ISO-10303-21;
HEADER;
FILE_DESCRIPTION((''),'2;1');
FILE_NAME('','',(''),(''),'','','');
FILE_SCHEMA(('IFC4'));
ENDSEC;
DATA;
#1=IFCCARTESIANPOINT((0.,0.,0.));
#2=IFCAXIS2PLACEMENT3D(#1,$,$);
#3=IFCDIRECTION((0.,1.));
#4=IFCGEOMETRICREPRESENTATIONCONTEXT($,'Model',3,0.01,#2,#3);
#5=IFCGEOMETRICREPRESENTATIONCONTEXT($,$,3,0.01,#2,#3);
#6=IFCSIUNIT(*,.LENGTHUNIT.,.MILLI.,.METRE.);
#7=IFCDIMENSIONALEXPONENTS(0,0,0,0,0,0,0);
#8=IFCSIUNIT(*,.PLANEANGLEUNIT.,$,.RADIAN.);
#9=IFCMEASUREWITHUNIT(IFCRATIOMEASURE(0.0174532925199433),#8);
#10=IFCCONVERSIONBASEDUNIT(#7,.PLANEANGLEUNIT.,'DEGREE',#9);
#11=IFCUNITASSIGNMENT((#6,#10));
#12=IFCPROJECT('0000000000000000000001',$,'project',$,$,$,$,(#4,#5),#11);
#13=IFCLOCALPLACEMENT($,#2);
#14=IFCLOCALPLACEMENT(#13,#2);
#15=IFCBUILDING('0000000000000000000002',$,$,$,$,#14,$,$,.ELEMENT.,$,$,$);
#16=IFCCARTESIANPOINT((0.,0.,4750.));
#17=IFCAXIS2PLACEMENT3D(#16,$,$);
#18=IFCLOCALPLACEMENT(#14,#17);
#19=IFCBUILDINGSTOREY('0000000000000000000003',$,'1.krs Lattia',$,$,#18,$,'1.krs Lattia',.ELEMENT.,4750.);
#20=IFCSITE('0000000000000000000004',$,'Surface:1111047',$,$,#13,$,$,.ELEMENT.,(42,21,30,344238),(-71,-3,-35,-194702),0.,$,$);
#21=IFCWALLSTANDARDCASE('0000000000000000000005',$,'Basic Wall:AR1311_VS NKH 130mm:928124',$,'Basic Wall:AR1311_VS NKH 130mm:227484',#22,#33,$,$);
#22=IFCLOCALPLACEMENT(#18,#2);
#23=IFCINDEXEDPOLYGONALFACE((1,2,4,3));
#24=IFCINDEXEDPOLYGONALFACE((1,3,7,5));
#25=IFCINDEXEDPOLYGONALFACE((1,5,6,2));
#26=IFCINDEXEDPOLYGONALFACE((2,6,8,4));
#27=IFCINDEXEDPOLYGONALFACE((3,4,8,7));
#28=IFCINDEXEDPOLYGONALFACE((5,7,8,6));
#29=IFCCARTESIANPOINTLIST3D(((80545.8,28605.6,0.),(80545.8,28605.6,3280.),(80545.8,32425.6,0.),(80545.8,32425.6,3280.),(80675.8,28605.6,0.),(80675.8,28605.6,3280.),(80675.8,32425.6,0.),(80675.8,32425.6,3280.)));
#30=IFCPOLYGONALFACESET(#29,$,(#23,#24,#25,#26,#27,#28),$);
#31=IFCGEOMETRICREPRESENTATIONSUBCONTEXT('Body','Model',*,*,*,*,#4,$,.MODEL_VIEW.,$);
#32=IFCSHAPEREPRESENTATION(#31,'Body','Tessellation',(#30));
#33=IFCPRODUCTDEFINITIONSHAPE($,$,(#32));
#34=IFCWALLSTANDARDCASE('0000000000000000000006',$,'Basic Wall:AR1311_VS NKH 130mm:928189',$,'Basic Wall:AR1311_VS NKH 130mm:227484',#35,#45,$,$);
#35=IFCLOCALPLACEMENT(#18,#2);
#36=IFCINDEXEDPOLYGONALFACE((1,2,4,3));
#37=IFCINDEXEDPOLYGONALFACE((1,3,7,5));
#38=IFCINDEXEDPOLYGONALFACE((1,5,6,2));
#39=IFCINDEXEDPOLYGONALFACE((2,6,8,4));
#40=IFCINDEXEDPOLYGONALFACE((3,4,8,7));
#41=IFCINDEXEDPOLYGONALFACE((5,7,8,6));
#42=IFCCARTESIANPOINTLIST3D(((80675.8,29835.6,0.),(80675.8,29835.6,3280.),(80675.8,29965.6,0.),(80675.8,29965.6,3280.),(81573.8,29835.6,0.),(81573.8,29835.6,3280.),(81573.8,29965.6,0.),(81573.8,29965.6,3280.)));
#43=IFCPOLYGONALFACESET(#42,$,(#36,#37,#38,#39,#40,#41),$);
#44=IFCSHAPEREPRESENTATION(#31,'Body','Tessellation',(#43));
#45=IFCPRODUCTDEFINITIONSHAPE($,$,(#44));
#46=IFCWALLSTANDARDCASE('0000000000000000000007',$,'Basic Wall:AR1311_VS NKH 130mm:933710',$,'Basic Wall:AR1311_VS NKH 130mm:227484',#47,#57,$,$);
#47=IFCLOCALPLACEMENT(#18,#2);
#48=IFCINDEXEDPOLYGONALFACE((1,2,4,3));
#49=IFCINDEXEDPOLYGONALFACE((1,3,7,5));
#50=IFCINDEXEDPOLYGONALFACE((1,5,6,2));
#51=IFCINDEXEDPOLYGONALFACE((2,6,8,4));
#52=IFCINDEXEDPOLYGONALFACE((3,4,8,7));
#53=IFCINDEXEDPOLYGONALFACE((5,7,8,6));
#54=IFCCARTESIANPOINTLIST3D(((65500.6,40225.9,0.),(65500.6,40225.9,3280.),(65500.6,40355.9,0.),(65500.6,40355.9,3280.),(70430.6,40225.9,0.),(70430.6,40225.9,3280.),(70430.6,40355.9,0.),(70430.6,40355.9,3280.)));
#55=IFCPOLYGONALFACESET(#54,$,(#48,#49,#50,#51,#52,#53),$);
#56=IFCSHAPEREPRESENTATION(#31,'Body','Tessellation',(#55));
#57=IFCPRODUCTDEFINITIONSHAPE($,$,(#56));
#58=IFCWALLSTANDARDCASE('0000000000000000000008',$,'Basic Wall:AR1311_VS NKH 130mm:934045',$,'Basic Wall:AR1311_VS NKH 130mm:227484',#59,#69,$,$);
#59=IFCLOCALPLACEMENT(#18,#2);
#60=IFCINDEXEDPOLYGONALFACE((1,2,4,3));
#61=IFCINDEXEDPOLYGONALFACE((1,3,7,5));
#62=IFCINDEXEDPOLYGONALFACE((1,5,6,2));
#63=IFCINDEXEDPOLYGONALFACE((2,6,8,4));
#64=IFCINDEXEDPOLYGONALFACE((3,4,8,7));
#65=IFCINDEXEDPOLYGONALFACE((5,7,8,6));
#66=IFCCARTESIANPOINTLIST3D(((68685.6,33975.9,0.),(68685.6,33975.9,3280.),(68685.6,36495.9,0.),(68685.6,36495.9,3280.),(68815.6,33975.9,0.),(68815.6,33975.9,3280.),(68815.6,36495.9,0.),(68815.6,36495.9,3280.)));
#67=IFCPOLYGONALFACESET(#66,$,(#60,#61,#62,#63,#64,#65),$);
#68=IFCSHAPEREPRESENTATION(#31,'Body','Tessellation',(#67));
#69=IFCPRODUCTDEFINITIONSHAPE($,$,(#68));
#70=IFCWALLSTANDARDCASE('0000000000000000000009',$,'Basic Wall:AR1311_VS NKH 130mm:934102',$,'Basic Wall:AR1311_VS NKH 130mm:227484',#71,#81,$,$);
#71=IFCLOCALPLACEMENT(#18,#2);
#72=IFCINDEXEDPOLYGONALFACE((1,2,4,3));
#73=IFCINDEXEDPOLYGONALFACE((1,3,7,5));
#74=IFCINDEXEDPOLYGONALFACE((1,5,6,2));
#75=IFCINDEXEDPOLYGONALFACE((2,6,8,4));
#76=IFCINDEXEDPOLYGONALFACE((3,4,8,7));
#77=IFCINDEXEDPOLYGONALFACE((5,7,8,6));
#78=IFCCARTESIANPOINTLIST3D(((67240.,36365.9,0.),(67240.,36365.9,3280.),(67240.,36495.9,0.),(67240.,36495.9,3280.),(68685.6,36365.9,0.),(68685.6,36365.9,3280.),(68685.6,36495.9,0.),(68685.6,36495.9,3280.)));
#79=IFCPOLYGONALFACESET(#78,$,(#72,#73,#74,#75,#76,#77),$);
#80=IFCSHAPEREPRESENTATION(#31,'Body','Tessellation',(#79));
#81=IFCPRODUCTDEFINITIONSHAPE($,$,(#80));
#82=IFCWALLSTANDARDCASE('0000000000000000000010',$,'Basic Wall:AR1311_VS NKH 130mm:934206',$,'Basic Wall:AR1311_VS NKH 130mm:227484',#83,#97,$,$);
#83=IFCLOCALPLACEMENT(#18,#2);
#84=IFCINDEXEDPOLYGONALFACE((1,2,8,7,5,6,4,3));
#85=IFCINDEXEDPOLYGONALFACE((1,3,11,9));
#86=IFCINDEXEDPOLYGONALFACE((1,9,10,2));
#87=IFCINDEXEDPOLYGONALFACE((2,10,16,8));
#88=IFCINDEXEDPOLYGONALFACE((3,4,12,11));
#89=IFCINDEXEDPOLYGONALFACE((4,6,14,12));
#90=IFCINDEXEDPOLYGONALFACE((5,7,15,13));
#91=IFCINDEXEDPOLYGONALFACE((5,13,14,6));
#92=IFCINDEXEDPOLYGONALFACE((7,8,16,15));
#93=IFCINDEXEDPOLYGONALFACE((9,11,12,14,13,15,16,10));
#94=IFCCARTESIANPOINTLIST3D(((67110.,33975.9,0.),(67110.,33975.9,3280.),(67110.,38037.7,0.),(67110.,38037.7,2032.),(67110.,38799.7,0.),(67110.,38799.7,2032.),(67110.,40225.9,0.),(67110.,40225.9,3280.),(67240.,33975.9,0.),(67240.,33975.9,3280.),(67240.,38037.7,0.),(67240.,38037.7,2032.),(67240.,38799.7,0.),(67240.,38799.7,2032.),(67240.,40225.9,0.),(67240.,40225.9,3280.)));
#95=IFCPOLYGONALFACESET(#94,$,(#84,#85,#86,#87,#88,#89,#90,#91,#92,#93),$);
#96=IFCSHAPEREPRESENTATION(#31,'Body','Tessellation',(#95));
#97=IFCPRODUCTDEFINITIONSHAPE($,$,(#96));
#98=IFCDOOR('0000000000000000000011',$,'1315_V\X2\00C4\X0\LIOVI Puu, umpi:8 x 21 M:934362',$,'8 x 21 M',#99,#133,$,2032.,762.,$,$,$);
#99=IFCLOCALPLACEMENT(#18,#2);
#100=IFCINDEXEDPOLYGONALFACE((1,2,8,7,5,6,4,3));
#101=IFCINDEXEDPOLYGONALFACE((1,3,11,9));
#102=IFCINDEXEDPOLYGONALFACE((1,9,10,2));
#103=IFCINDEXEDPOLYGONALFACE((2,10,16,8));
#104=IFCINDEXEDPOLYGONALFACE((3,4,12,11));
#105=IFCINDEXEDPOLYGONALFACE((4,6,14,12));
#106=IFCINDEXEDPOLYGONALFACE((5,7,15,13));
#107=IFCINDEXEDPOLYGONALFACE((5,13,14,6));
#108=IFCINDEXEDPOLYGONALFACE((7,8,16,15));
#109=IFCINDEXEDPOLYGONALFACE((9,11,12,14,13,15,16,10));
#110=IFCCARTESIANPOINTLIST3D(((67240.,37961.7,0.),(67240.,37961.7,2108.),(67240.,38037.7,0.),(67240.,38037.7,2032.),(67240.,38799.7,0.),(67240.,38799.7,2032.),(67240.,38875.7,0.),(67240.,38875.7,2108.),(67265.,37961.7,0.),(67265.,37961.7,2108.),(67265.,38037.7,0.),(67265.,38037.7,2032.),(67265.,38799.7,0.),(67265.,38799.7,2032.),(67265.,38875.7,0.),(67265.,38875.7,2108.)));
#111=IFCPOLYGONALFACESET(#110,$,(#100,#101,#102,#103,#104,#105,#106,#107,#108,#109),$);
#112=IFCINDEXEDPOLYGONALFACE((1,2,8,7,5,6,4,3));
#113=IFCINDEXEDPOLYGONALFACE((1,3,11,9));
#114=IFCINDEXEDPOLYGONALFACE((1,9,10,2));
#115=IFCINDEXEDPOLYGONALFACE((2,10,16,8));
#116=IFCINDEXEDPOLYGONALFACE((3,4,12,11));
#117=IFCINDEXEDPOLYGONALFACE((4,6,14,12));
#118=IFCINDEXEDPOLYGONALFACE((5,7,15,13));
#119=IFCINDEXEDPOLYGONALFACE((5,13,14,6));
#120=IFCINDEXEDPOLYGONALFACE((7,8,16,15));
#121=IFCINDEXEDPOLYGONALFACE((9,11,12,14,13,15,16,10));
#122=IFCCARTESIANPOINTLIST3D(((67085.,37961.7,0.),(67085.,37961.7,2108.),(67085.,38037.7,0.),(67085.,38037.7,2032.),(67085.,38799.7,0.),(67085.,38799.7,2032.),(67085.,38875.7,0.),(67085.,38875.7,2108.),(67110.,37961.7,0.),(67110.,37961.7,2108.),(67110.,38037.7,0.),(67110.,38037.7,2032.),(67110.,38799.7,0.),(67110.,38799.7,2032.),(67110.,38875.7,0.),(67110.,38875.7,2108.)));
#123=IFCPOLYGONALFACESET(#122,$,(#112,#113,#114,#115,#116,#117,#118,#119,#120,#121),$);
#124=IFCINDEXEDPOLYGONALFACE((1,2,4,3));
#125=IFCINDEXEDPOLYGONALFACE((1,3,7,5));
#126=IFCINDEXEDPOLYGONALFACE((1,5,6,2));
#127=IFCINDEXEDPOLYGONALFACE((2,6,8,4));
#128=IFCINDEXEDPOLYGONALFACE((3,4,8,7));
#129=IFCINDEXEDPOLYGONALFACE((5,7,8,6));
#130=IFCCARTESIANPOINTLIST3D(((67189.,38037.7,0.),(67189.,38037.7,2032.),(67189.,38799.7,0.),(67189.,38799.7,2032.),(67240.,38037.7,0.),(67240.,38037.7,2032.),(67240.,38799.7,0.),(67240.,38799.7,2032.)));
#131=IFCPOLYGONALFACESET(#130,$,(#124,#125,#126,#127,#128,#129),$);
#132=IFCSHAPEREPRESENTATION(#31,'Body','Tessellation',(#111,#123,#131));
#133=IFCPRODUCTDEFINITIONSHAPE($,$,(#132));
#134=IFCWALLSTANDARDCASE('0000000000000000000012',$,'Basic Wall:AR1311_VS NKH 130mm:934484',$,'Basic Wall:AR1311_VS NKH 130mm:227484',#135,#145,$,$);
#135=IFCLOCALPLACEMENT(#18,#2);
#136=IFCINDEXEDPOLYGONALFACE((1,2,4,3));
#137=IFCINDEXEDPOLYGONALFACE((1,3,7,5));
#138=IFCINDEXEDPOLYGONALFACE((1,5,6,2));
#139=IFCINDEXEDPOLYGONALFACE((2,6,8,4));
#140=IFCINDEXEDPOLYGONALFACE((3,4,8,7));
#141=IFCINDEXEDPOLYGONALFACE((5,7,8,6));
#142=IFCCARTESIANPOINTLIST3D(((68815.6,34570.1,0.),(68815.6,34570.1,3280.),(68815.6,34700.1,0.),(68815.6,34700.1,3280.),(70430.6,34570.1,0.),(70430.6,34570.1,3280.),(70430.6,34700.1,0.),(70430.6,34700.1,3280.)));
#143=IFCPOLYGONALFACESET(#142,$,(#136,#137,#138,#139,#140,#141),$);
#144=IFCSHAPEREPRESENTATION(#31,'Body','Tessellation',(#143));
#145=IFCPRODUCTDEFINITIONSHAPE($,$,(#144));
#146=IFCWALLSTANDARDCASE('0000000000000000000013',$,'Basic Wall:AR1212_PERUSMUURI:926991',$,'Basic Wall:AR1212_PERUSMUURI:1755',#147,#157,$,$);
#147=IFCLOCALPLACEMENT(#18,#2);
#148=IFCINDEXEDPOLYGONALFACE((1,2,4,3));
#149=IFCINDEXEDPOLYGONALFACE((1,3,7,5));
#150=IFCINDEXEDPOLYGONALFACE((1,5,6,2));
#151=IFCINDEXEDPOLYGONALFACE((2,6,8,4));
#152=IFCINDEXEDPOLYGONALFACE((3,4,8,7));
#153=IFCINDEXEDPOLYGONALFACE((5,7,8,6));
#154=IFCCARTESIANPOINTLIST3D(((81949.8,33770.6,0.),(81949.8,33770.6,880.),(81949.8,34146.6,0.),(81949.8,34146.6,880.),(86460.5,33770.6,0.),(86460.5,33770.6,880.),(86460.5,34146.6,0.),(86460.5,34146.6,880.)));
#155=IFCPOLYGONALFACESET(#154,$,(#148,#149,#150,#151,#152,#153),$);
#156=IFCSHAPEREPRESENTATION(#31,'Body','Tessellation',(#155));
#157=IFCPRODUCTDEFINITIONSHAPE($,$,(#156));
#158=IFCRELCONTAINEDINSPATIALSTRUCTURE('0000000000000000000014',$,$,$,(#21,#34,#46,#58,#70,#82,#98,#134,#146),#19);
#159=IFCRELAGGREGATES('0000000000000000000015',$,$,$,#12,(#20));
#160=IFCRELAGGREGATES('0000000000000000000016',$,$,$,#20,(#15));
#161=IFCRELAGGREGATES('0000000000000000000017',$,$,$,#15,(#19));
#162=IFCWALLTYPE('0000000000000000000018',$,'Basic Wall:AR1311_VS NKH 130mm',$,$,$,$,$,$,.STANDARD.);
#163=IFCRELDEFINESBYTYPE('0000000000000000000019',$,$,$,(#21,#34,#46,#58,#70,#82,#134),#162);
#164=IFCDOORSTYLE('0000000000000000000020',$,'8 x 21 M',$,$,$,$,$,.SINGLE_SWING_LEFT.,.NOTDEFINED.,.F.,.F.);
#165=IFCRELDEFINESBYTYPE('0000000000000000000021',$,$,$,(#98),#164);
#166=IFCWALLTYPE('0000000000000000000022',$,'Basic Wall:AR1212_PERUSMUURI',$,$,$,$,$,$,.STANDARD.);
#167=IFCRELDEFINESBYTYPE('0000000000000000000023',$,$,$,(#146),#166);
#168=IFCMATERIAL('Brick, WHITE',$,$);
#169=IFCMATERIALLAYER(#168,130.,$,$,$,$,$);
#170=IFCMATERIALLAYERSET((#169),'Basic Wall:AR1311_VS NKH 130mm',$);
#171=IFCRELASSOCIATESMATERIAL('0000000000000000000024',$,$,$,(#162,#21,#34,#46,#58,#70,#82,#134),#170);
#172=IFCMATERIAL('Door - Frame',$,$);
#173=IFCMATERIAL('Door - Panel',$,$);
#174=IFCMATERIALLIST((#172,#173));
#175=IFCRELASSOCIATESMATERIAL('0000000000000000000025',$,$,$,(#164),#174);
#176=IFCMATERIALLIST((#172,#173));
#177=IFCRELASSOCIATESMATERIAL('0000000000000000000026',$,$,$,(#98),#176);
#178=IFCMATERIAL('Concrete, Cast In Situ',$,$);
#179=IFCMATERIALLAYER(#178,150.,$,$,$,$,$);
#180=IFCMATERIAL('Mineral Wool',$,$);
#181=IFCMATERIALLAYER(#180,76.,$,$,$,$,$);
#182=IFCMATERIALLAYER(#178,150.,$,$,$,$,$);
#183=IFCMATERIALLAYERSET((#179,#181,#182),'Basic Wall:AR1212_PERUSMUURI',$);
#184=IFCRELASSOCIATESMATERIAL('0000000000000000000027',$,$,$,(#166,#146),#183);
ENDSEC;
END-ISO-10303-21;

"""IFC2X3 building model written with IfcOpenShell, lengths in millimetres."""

from ifc_helpers import new_model, entity, si_unit, converted_unit, direction, frame, frame_2d, origin, place, context, subcontext, project, spatial, polyline, rectangle, outline, extrude, clip, bounded_halfspace, source, transform, mapped, material, material_list, layer, layer_set, layer_usage, type_object, type_shapes, element, fill, save


model = new_model("IFC2X3")

# Units and contexts
model_context = context("Model", 3, precision=0.01, world=origin(), true_north=direction((0.0, 1.0)))
context_of_model = context(None, 3, precision=0.01, world=origin(), true_north=direction((0.0, 1.0)))
body_context = subcontext(model_context, "Body", "Model", "MODEL_VIEW")
ifc_project = project(units=[si_unit("LENGTHUNIT", "METRE", prefix="MILLI"), converted_unit("PLANEANGLEUNIT", "DEGREE", entity("IfcRatioMeasure", 0.0174532925199433), si_unit("PLANEANGLEUNIT", "RADIAN"), dimensions=[0, 0, 0, 0, 0, 0, 0])], contexts=[model_context, context_of_model])

# Site, building, storey
site_placement = place(None, origin())
site = spatial("IfcSite", under=ifc_project, at=site_placement, Name="Surface:1111047", CompositionType="ELEMENT", RefLatitude=(42, 21, 30, 344238), RefLongitude=(-71, -3, -35, -194702), RefElevation=0.0)
building_placement = place(site_placement, origin())
building = spatial("IfcBuilding", under=site, at=building_placement, CompositionType="ELEMENT")
storey_placement = place(building_placement, frame((0.0, 0.0, 4750.0)))
storey = spatial("IfcBuildingStorey", under=building, at=storey_placement, Name="1.krs Lattia", LongName="1.krs Lattia", CompositionType="ELEMENT", Elevation=4750.0)

# Walls
ifc_material_1 = material(Name="Brick, WHITE")
ifc_layer_1 = layer(ifc_material_1, 130.0)
ifc_layer_set_1 = layer_set([ifc_layer_1], Name="Basic Wall:AR1311_VS NKH 130mm")
ifc_layer_usage_1 = layer_usage(ifc_layer_set_1, "AXIS2", "NEGATIVE", 65.0)
wall_type_1 = type_object("IfcWallType", Name="Basic Wall:AR1311_VS NKH 130mm", PredefinedType="STANDARD", material=ifc_layer_set_1)
wall_1_placement = place(storey_placement, frame((80610.8, 32425.6, 0.0), z_axis=(0.0, 0.0, 1.0), x_axis=(0.0, -1.0, 0.0)))
element("IfcWallStandardCase", 1, at=wall_1_placement, inside=storey, type_object=wall_type_1, material=ifc_layer_usage_1, Name="Basic Wall:AR1311_VS NKH 130mm:928124", ObjectType="Basic Wall:AR1311_VS NKH 130mm:227484", context=body_context, shape_type="SweptSolid", body=[
    extrude(rectangle(XDim=3820.0, YDim=130.0, at=frame_2d((1910.0, 0.0), x_axis=(-1.0, 0.0))), origin(), (0.0, 0.0, 1.0), 3280.0),
])
ifc_layer_usage_2 = layer_usage(ifc_layer_set_1, "AXIS2", "NEGATIVE", 65.0)
wall_2_placement = place(storey_placement, frame((80675.8, 29900.6, 0.0)))
element("IfcWallStandardCase", 2, at=wall_2_placement, inside=storey, type_object=wall_type_1, material=ifc_layer_usage_2, Name="Basic Wall:AR1311_VS NKH 130mm:928189", ObjectType="Basic Wall:AR1311_VS NKH 130mm:227484", context=body_context, shape_type="SweptSolid", body=[
    extrude(rectangle(XDim=898.0, YDim=130.0, at=frame_2d((449.0, 0.0), x_axis=(-1.0, 0.0))), origin(), (0.0, 0.0, 1.0), 3280.0),
])
ifc_layer_usage_3 = layer_usage(ifc_layer_set_1, "AXIS2", "NEGATIVE", 65.0)
wall_3_placement = place(storey_placement, frame((70430.6, 40290.9, 0.0), z_axis=(0.0, 0.0, 1.0), x_axis=(-1.0, 0.0, 0.0)))
element("IfcWallStandardCase", 3, at=wall_3_placement, inside=storey, type_object=wall_type_1, material=ifc_layer_usage_3, Name="Basic Wall:AR1311_VS NKH 130mm:933710", ObjectType="Basic Wall:AR1311_VS NKH 130mm:227484", context=body_context, shape_type="Clipping", body=[
    clip(extrude(rectangle(XDim=4930.0, YDim=130.0, at=frame_2d((2465.0, 0.0), x_axis=(-1.0, 0.0))), origin(), (0.0, 0.0, 1.0), 3280.0), bounded_halfspace(frame((0.0, -65.0, 3280.0), z_axis=(0.0, 0.0, -1.0), x_axis=(1.0, 0.0, 0.0)), True, frame((0.0, -65.0, 3280.0)), polyline([(0.0, 0.0), (4930.0, 0.0), (4930.0, 130.0), (3320.6, 130.0), (3190.6, 130.0), (0.0, 130.0), (0.0, 0.0)]))),
])
ifc_layer_usage_4 = layer_usage(ifc_layer_set_1, "AXIS2", "NEGATIVE", 65.0)
wall_4_placement = place(storey_placement, frame((68750.6, 33975.9, 0.0), z_axis=(0.0, 0.0, 1.0), x_axis=(0.0, 1.0, 0.0)))
element("IfcWallStandardCase", 4, at=wall_4_placement, inside=storey, type_object=wall_type_1, material=ifc_layer_usage_4, Name="Basic Wall:AR1311_VS NKH 130mm:934045", ObjectType="Basic Wall:AR1311_VS NKH 130mm:227484", context=body_context, shape_type="Clipping", body=[
    clip(extrude(rectangle(XDim=2520.0, YDim=130.0, at=frame_2d((1260.0, 0.0), x_axis=(-1.0, 0.0))), origin(), (0.0, 0.0, 1.0), 3280.0), bounded_halfspace(frame((0.0, -65.0, 3280.0), z_axis=(0.0, 0.0, -1.0), x_axis=(0.0, 1.0, 0.0)), True, frame((0.0, -65.0, 3280.0)), polyline([(0.0, 0.0), (594.2, 0.0), (724.2, 0.0), (2520.0, 0.0), (2520.0, 130.0), (2390.0, 130.0), (0.0, 130.0), (0.0, 0.0)]))),
])
ifc_layer_usage_5 = layer_usage(ifc_layer_set_1, "AXIS2", "NEGATIVE", 65.0)
wall_5_placement = place(storey_placement, frame((68685.6, 36430.9, 0.0), z_axis=(0.0, 0.0, 1.0), x_axis=(-1.0, 0.0, 0.0)))
element("IfcWallStandardCase", 5, at=wall_5_placement, inside=storey, type_object=wall_type_1, material=ifc_layer_usage_5, Name="Basic Wall:AR1311_VS NKH 130mm:934102", ObjectType="Basic Wall:AR1311_VS NKH 130mm:227484", context=body_context, shape_type="Clipping", body=[
    clip(extrude(rectangle(XDim=1445.6, YDim=130.0, at=frame_2d((722.8, 0.0), x_axis=(-1.0, 0.0))), origin(), (0.0, 0.0, 1.0), 3280.0), bounded_halfspace(frame((0.0, -65.0, 3280.0), z_axis=(0.0, 0.0, -1.0), x_axis=(1.0, 0.0, 0.0)), True, frame((0.0, -65.0, 3280.0)), polyline([(0.0, 0.0), (1445.6, 0.0), (1445.6, 130.0), (0.0, 130.0), (0.0, 0.0)]))),
])

# Wall, opening, door
ifc_layer_usage_6 = layer_usage(ifc_layer_set_1, "AXIS2", "NEGATIVE", 65.0)
wall_6_placement = place(storey_placement, frame((67175.0, 33975.9, 0.0), z_axis=(0.0, 0.0, 1.0), x_axis=(0.0, 1.0, 0.0)))
wall_6 = element("IfcWallStandardCase", 6, at=wall_6_placement, inside=storey, type_object=wall_type_1, material=ifc_layer_usage_6, Name="Basic Wall:AR1311_VS NKH 130mm:934206", ObjectType="Basic Wall:AR1311_VS NKH 130mm:227484", context=body_context, shape_type="Clipping", body=[
    clip(extrude(rectangle(XDim=6250.0, YDim=130.0, at=frame_2d((3125.0, 0.0), x_axis=(-1.0, 0.0))), origin(), (0.0, 0.0, 1.0), 3280.0), bounded_halfspace(frame((0.0, -65.0, 3280.0), z_axis=(0.0, 0.0, -1.0), x_axis=(0.0, 1.0, 0.0)), True, frame((0.0, -65.0, 3280.0)), polyline([(0.0, 0.0), (2390.0, 0.0), (2520.0, 0.0), (6250.0, 0.0), (6250.0, 130.0), (0.0, 130.0), (0.0, 0.0)]))),
])
opening_1_placement = place(wall_6_placement, frame((4823.8, 65.0, 0.0)))
opening_1 = element("IfcOpeningElement", 7, at=opening_1_placement, cuts=wall_6, ObjectType="Opening", context=body_context, shape_type="SweptSolid", body=[
    extrude(rectangle(XDim=762.0, YDim=2032.0, at=frame_2d((1016.0, 381.0), x_axis=(0.0, -1.0))), frame((0.0, 0.0, 0.0), z_axis=(0.0, -1.0, 0.0), x_axis=(0.0, 0.0, 1.0)), (0.0, 0.0, 1.0), 130.0),
])
ifc_material_2 = material(Name="Door - Frame")
ifc_material_3 = material(Name="Door - Panel")
ifc_material_list_1 = material_list([ifc_material_2, ifc_material_3])
ifc_material_list_2 = material_list([ifc_material_2, ifc_material_3])
door_style_1 = type_object("IfcDoorStyle", Name="8 x 21 M", ConstructionType="NOTDEFINED", OperationType="SINGLE_SWING_LEFT", ParameterTakesPrecedence=False, Sizeable=False, material=ifc_material_list_2)
shared_shape_1 = source(origin(), body_context, "Body", "SweptSolid", [
    extrude(outline(polyline([(-457.0, -1073.0), (457.0, -1073.0), (457.0, 1035.0), (381.0, 1035.0), (381.0, -997.0), (-381.0, -997.0), (-381.0, 1035.0), (-457.0, 1035.0), (-457.0, -1073.0)])), frame((381.0, 155.0, 1035.0), z_axis=(0.0, -1.0, 0.0), x_axis=(-1.0, 0.0, 0.0)), (0.0, 0.0, 1.0), 25.0),
    extrude(outline(polyline([(-1073.0, -457.0), (1035.0, -457.0), (1035.0, -381.0), (-997.0, -381.0), (-997.0, 381.0), (1035.0, 381.0), (1035.0, 457.0), (-1073.0, 457.0), (-1073.0, -457.0)])), frame((381.0, 0.0, 1035.0), z_axis=(0.0, -1.0, 0.0), x_axis=(0.0, 0.0, -1.0)), (0.0, 0.0, 1.0), 25.0),
    extrude(rectangle(XDim=762.0, YDim=51.0, at=frame_2d((0.0, 0.0), x_axis=(1.0, 0.0))), frame((381.0, 104.5, 0.0)), (0.0, 0.0, 1.0), 2032.0),
])
type_shapes(door_style_1, [shared_shape_1])
door_1_placement = place(opening_1_placement, frame((0.0, 0.0, 0.0), z_axis=(0.0, 0.0, 1.0), x_axis=(-1.0, 0.0, 0.0)))
door_1 = element("IfcDoor", 8, at=door_1_placement, inside=storey, type_object=door_style_1, material=ifc_material_list_1, Name="1315_VÄLIOVI Puu, umpi:8 x 21 M:934362", ObjectType="8 x 21 M", OverallHeight=2032.0, OverallWidth=762.0, context=body_context, shape_type="MappedRepresentation", body=[
    mapped(shared_shape_1, transform((0.0, 0.0, 0.0), scale=1.0)),
])
fill(opening_1, door_1)

# Walls
ifc_layer_usage_7 = layer_usage(ifc_layer_set_1, "AXIS2", "NEGATIVE", 65.0)
wall_7_placement = place(storey_placement, frame((68815.6, 34635.1, 0.0)))
element("IfcWallStandardCase", 9, at=wall_7_placement, inside=storey, type_object=wall_type_1, material=ifc_layer_usage_7, Name="Basic Wall:AR1311_VS NKH 130mm:934484", ObjectType="Basic Wall:AR1311_VS NKH 130mm:227484", context=body_context, shape_type="Clipping", body=[
    clip(extrude(rectangle(XDim=1615.0, YDim=130.0, at=frame_2d((807.5, 0.0), x_axis=(-1.0, 0.0))), origin(), (0.0, 0.0, 1.0), 3280.0), bounded_halfspace(frame((0.0, -65.0, 3280.0), z_axis=(0.0, 0.0, -1.0), x_axis=(-1.0, 0.0, 0.0)), True, frame((0.0, -65.0, 3280.0)), polyline([(0.0, 0.0), (1615.0, 0.0), (1615.0, 130.0), (0.0, 130.0), (0.0, 0.0)]))),
])
ifc_material_4 = material(Name="Concrete, Cast In Situ")
ifc_layer_2 = layer(ifc_material_4, 150.0)
ifc_material_5 = material(Name="Mineral Wool")
ifc_layer_3 = layer(ifc_material_5, 76.0)
ifc_layer_4 = layer(ifc_material_4, 150.0)
ifc_layer_set_2 = layer_set([ifc_layer_2, ifc_layer_3, ifc_layer_4], Name="Basic Wall:AR1212_PERUSMUURI")
ifc_layer_usage_8 = layer_usage(ifc_layer_set_2, "AXIS2", "NEGATIVE", 188.0)
wall_type_2 = type_object("IfcWallType", Name="Basic Wall:AR1212_PERUSMUURI", PredefinedType="STANDARD", material=ifc_layer_set_2)
wall_8_placement = place(storey_placement, frame((81949.8, 33958.6, 0.0)))
element("IfcWallStandardCase", 10, at=wall_8_placement, inside=storey, type_object=wall_type_2, material=ifc_layer_usage_8, Name="Basic Wall:AR1212_PERUSMUURI:926991", ObjectType="Basic Wall:AR1212_PERUSMUURI:1755", context=body_context, shape_type="SweptSolid", body=[
    extrude(rectangle(XDim=4510.7, YDim=376.0, at=frame_2d((2255.3, 0.0), x_axis=(-1.0, 0.0))), origin(), (0.0, 0.0, 1.0), 880.0),
])

save(model, "model.ifc")
